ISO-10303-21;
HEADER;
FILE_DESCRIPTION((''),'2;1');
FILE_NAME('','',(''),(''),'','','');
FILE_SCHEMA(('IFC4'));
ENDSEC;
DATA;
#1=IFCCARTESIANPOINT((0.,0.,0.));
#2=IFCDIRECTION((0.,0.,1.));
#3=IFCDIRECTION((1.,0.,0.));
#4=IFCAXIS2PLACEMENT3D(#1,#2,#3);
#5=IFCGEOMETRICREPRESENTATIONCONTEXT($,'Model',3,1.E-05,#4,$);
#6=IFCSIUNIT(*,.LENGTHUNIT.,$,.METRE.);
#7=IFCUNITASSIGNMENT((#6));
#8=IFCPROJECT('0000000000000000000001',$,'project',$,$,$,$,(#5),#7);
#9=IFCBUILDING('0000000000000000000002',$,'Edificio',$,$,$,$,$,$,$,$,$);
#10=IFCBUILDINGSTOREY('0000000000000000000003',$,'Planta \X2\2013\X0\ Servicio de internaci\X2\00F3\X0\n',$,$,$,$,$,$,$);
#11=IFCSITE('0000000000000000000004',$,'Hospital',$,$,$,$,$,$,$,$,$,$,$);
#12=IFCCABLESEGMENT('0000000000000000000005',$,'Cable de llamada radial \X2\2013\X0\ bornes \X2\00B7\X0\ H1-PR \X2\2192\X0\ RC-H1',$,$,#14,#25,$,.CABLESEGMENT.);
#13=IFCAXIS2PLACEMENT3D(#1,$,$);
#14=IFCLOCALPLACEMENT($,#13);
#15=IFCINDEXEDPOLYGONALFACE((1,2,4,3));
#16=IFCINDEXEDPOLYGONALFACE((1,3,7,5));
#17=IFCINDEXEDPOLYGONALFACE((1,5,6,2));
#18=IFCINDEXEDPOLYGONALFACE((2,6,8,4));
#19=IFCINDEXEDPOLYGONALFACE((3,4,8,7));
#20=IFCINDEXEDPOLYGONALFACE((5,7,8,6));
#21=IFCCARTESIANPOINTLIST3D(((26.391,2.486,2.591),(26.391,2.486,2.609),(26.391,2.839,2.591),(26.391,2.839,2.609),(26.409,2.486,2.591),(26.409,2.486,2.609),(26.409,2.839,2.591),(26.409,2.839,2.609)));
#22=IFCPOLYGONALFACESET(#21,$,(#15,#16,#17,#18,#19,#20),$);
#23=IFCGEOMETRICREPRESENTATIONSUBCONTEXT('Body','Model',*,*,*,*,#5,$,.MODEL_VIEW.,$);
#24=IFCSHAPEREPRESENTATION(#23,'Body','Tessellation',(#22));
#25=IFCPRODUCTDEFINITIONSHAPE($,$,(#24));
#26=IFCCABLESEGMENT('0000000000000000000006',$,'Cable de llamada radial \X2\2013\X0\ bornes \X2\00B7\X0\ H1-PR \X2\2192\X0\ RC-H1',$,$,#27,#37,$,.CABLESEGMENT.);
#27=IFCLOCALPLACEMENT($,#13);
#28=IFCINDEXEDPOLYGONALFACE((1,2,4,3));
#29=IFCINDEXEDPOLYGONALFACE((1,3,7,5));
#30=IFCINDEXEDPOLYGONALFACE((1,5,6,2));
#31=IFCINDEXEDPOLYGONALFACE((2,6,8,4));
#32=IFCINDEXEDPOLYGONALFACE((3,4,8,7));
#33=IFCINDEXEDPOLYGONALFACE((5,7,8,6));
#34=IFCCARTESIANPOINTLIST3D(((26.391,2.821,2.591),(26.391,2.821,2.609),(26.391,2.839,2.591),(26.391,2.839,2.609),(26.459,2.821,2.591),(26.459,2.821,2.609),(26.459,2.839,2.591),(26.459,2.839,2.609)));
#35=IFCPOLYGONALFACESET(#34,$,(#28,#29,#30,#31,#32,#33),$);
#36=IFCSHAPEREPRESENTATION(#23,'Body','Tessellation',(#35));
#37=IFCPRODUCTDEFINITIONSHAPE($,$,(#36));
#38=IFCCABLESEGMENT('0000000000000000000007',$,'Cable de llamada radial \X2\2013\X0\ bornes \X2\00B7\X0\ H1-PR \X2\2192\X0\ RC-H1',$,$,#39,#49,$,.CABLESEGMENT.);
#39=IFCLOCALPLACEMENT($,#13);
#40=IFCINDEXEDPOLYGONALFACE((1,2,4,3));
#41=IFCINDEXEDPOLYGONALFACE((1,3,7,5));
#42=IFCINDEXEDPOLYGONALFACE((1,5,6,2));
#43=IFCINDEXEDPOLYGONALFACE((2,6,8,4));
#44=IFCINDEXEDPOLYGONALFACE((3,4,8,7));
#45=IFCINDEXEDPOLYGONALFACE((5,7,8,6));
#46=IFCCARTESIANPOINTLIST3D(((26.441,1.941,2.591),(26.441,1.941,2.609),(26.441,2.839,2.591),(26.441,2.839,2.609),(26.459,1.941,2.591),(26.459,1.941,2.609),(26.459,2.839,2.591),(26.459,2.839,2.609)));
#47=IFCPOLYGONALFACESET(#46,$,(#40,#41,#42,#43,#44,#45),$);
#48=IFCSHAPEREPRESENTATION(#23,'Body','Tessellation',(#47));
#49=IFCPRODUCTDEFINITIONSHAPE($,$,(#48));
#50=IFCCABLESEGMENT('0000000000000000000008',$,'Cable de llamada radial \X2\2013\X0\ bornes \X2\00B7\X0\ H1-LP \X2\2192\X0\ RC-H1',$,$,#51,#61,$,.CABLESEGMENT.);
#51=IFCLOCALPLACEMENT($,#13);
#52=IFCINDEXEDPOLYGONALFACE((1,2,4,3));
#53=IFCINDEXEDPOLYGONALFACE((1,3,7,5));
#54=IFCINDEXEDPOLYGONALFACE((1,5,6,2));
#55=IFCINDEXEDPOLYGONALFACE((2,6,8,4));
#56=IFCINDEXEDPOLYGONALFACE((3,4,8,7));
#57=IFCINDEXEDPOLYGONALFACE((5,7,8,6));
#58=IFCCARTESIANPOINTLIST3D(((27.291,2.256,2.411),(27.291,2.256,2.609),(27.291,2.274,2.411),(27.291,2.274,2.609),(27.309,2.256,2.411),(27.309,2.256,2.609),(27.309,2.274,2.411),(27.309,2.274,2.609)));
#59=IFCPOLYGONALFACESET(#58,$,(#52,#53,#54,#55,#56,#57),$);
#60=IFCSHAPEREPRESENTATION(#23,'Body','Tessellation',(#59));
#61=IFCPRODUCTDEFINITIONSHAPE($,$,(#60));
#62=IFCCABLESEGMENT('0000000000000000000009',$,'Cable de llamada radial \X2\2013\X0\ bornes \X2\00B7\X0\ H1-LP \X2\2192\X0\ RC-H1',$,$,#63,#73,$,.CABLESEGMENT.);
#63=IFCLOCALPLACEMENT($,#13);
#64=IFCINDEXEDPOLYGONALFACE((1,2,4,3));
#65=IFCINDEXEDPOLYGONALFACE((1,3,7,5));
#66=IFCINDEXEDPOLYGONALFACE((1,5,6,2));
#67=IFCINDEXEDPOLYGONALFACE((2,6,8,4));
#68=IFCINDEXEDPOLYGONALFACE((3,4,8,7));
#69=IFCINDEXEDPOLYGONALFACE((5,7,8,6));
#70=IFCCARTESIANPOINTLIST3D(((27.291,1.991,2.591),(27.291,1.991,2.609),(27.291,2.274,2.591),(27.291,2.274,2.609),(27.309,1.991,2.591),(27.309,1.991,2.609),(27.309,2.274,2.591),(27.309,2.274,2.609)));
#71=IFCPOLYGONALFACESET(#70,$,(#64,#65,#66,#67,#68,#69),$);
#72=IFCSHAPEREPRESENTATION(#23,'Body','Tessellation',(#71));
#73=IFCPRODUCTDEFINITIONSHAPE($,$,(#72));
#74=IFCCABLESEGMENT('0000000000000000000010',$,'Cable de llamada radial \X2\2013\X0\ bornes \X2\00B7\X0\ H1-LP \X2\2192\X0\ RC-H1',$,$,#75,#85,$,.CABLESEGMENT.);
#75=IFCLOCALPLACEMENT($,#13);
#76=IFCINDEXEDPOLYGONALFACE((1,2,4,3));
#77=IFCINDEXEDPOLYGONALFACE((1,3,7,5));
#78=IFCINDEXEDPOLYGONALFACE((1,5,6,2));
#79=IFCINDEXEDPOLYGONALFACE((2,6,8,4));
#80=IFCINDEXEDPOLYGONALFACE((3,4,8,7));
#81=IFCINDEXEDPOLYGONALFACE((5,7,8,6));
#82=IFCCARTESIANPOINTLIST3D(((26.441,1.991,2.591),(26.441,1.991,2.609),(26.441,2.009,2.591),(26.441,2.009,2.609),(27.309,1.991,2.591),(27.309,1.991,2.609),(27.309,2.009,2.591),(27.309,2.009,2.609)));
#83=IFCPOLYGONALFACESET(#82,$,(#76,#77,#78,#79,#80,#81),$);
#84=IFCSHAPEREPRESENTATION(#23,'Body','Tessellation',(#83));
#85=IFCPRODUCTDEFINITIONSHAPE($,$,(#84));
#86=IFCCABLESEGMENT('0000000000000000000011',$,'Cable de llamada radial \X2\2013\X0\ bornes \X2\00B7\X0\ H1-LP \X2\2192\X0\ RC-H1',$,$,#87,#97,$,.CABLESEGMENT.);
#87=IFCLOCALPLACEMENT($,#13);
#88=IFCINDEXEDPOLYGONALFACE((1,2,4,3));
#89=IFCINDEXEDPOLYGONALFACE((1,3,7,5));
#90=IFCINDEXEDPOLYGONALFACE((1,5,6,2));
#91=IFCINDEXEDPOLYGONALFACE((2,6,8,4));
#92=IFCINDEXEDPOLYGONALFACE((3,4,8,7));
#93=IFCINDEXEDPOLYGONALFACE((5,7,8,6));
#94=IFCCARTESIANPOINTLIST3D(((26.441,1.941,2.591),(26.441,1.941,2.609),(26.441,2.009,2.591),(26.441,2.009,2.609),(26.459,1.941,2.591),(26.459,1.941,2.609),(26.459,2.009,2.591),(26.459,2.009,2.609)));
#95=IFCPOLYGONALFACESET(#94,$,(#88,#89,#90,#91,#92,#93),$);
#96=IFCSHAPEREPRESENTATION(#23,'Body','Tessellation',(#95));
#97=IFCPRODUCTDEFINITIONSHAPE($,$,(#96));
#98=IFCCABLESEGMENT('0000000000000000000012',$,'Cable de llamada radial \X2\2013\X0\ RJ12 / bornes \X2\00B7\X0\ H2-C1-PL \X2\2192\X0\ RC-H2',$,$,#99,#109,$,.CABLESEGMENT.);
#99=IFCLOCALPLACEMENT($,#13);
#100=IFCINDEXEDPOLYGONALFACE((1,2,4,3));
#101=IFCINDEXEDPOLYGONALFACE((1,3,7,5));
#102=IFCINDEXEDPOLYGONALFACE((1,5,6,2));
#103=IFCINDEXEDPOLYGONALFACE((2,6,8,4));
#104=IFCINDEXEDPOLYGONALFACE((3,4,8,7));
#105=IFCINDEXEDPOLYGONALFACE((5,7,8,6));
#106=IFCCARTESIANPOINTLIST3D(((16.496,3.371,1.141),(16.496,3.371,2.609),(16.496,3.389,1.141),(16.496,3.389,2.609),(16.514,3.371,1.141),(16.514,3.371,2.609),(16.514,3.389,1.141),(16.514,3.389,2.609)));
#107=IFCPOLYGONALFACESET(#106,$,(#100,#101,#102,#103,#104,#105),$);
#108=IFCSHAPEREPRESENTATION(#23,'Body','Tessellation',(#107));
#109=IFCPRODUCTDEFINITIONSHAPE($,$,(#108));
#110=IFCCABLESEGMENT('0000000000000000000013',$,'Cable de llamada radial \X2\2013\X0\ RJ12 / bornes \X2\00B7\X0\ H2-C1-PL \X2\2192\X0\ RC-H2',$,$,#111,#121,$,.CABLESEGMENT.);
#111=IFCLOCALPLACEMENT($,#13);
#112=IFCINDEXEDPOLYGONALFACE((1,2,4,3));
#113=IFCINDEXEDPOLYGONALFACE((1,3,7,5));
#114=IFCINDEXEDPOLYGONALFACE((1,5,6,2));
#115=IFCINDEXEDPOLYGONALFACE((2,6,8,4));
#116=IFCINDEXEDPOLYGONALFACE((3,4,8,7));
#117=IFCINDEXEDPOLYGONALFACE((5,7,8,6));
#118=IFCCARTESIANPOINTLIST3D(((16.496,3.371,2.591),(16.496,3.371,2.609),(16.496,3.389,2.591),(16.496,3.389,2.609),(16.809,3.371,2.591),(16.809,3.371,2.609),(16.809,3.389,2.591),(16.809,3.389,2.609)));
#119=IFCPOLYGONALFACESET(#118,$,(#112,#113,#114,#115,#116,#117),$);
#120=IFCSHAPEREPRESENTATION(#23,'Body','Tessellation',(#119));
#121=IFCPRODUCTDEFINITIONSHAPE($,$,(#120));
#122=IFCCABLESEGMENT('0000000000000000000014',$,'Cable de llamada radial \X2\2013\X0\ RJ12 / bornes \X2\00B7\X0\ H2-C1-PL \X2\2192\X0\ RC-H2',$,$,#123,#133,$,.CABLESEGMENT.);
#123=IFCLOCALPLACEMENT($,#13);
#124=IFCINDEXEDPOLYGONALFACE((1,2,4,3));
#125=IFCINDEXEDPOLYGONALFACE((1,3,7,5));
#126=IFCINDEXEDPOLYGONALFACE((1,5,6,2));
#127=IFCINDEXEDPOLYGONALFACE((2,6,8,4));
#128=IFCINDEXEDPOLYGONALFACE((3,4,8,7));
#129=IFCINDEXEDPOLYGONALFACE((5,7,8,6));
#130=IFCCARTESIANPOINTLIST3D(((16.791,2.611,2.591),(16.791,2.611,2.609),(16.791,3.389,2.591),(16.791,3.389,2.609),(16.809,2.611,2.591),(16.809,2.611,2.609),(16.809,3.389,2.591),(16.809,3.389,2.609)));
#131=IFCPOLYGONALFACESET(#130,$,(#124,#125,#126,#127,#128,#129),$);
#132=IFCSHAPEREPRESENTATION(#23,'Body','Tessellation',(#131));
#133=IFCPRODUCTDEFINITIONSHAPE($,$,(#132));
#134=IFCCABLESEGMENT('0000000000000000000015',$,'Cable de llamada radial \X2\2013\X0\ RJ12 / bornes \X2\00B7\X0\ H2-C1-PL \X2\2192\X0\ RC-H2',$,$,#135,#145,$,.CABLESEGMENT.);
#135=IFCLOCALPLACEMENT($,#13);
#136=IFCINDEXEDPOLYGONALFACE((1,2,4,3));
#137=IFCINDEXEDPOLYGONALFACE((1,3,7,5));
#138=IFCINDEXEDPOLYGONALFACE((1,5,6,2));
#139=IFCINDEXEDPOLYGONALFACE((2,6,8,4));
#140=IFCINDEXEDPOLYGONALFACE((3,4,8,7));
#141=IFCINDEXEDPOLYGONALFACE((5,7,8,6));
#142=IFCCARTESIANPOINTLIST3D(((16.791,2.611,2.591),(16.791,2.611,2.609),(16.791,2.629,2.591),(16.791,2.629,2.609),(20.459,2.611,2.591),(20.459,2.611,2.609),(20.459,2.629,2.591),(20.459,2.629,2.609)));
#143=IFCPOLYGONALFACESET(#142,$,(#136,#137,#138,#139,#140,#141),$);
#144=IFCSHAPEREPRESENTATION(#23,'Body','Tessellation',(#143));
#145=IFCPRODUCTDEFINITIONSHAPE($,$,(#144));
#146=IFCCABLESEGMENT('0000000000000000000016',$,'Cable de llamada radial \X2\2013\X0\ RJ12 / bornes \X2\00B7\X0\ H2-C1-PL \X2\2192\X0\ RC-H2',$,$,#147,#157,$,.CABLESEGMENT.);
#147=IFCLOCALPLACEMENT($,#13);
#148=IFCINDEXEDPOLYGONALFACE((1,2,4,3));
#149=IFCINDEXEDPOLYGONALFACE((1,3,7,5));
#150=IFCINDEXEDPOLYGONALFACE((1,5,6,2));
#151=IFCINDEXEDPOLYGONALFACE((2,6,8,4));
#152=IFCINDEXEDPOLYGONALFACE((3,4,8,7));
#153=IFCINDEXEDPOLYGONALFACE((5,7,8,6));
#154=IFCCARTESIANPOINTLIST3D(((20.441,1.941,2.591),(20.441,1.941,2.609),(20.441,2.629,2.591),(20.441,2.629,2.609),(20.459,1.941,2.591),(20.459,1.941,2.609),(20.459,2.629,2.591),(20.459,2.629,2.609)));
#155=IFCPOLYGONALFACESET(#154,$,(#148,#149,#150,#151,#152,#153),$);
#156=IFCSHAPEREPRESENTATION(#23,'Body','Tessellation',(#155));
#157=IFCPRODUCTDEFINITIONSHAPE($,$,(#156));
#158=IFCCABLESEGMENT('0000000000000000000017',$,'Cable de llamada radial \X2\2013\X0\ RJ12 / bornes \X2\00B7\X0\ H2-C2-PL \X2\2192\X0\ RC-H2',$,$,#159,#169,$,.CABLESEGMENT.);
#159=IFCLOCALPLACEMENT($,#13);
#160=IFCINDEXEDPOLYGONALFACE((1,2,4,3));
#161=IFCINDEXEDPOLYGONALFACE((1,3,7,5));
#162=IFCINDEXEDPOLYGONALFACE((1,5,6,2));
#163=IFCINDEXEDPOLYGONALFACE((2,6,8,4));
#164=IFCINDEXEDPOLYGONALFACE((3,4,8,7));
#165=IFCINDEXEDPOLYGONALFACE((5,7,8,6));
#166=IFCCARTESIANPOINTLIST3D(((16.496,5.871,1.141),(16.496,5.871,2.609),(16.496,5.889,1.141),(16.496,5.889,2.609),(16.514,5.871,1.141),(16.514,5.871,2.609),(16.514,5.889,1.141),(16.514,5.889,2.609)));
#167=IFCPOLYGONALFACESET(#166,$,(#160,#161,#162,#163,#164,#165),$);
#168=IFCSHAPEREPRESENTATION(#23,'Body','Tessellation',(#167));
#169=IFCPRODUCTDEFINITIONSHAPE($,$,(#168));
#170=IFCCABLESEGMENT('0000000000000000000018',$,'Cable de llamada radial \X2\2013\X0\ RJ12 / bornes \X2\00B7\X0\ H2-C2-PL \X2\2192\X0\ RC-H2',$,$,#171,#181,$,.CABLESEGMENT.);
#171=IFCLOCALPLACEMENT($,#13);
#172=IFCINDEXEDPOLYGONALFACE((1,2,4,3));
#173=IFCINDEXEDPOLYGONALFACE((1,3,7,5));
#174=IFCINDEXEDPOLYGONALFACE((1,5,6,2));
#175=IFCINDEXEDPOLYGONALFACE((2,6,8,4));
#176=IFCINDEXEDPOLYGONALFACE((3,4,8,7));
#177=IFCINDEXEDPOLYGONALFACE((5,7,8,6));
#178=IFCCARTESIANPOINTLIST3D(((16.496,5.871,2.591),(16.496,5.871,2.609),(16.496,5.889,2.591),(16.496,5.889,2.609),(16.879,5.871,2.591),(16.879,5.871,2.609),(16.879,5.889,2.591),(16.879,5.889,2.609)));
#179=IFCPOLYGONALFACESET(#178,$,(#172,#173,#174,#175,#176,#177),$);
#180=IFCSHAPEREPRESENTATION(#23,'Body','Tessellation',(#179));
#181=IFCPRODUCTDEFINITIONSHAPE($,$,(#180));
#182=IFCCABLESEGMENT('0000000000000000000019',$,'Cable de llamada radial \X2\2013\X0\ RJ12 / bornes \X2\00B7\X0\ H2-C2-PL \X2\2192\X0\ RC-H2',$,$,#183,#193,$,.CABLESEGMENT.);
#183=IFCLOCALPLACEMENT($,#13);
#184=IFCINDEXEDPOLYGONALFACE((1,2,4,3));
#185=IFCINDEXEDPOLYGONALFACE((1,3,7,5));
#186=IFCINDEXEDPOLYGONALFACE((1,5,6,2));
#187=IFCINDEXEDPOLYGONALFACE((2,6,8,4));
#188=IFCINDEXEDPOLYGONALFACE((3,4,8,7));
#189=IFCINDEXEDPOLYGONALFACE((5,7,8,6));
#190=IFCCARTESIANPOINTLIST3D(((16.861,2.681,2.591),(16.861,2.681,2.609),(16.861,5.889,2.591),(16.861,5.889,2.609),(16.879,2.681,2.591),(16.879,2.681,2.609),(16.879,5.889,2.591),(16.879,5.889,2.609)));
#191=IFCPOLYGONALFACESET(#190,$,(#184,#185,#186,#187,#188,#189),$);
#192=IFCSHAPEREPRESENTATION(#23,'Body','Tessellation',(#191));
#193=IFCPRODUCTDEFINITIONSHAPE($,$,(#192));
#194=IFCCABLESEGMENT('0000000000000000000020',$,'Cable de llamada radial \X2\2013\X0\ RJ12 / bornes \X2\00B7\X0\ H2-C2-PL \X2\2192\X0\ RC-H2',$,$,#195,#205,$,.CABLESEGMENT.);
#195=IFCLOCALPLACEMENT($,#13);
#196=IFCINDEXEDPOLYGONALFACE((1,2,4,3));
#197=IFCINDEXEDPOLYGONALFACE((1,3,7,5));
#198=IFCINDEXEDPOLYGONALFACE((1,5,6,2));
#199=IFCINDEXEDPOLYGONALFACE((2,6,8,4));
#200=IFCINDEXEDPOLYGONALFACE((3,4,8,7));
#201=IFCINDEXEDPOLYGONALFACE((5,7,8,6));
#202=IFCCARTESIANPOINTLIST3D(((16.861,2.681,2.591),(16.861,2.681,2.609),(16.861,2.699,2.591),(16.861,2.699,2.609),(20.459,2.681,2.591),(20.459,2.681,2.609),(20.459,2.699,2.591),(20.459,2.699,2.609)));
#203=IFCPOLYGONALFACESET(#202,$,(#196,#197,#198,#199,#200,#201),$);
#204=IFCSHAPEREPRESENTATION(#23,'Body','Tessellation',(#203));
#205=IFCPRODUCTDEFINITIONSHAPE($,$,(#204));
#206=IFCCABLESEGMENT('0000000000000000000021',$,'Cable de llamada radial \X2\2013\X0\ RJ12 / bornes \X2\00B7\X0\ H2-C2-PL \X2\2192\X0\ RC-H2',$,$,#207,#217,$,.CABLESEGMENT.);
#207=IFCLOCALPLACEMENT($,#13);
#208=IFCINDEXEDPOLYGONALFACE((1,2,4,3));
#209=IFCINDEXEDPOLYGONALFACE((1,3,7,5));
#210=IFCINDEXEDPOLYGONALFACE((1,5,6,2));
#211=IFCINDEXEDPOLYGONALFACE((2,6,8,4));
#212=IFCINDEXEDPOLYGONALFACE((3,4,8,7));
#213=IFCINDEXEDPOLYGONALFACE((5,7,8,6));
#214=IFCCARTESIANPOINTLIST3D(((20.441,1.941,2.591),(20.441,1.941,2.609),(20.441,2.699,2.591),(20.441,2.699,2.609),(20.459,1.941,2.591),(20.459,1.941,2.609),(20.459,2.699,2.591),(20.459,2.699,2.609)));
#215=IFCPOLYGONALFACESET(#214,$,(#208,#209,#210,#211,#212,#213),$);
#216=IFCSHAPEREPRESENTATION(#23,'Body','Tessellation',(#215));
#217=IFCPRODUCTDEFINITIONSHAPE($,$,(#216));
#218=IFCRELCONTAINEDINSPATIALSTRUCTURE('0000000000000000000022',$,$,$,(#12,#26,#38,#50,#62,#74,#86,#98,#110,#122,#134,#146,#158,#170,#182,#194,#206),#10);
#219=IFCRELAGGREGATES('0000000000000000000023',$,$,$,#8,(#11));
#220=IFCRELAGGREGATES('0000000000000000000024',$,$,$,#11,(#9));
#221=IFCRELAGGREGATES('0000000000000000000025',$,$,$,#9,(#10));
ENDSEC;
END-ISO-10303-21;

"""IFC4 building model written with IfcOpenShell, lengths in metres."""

from ifc_helpers import new_model, si_unit, frame, origin_with_axes, context, subcontext, project, spatial, line, indexed_curve, outline, extrude, element, save


model = new_model("IFC4")

# Units and contexts
model_context = context("Model", 3, precision=1e-05, world=origin_with_axes())
body_context = subcontext(model_context, "Body", "Model", "MODEL_VIEW")
ifc_project = project(units=[si_unit("LENGTHUNIT", "METRE")], contexts=[model_context])

# Site, building, storey
site = spatial("IfcSite", under=ifc_project, Name="Hospital")
building = spatial("IfcBuilding", under=site, Name="Edificio")
storey = spatial("IfcBuildingStorey", under=building, Name="Planta – Servicio de internación")

# Cable segments
element("IfcCableSegment", 1, inside=storey, Name="Cable de llamada radial – bornes · H1-PR → RC-H1", PredefinedType="CABLESEGMENT", context=body_context, shape_type="SweptSolid", body=[
    extrude(outline(indexed_curve([(0.0, 0.0), (0.018, 0.0), (0.018, 0.353), (0.0, 0.353)], segments=[line(1, 2, 3, 4, 1)])), frame((26.391, 2.486, 2.591), z_axis=(0.0, 0.0, 1.0), x_axis=(1.0, 0.0, 0.0)), (0.0, 0.0, 1.0), 0.018),
])
element("IfcCableSegment", 2, inside=storey, Name="Cable de llamada radial – bornes · H1-PR → RC-H1", PredefinedType="CABLESEGMENT", context=body_context, shape_type="SweptSolid", body=[
    extrude(outline(indexed_curve([(0.0, 0.0), (0.068, 0.0), (0.068, 0.018), (0.0, 0.018)], segments=[line(1, 2, 3, 4, 1)])), frame((26.391, 2.821, 2.591), z_axis=(0.0, 0.0, 1.0), x_axis=(1.0, 0.0, 0.0)), (0.0, 0.0, 1.0), 0.018),
])
element("IfcCableSegment", 3, inside=storey, Name="Cable de llamada radial – bornes · H1-PR → RC-H1", PredefinedType="CABLESEGMENT", context=body_context, shape_type="SweptSolid", body=[
    extrude(outline(indexed_curve([(0.0, 0.0), (0.018, 0.0), (0.018, 0.898), (0.0, 0.898)], segments=[line(1, 2, 3, 4, 1)])), frame((26.441, 1.941, 2.591), z_axis=(0.0, 0.0, 1.0), x_axis=(1.0, 0.0, 0.0)), (0.0, 0.0, 1.0), 0.018),
])
element("IfcCableSegment", 4, inside=storey, Name="Cable de llamada radial – bornes · H1-LP → RC-H1", PredefinedType="CABLESEGMENT", context=body_context, shape_type="SweptSolid", body=[
    extrude(outline(indexed_curve([(0.0, 0.0), (0.018, 0.0), (0.018, 0.018), (0.0, 0.018)], segments=[line(1, 2, 3, 4, 1)])), frame((27.291, 2.256, 2.411), z_axis=(0.0, 0.0, 1.0), x_axis=(1.0, 0.0, 0.0)), (0.0, 0.0, 1.0), 0.198),
])
element("IfcCableSegment", 5, inside=storey, Name="Cable de llamada radial – bornes · H1-LP → RC-H1", PredefinedType="CABLESEGMENT", context=body_context, shape_type="SweptSolid", body=[
    extrude(outline(indexed_curve([(0.0, 0.0), (0.018, 0.0), (0.018, 0.283), (0.0, 0.283)], segments=[line(1, 2, 3, 4, 1)])), frame((27.291, 1.991, 2.591), z_axis=(0.0, 0.0, 1.0), x_axis=(1.0, 0.0, 0.0)), (0.0, 0.0, 1.0), 0.018),
])
element("IfcCableSegment", 6, inside=storey, Name="Cable de llamada radial – bornes · H1-LP → RC-H1", PredefinedType="CABLESEGMENT", context=body_context, shape_type="SweptSolid", body=[
    extrude(outline(indexed_curve([(0.0, 0.0), (0.868, 0.0), (0.868, 0.018), (0.0, 0.018)], segments=[line(1, 2, 3, 4, 1)])), frame((26.441, 1.991, 2.591), z_axis=(0.0, 0.0, 1.0), x_axis=(1.0, 0.0, 0.0)), (0.0, 0.0, 1.0), 0.018),
])
element("IfcCableSegment", 7, inside=storey, Name="Cable de llamada radial – bornes · H1-LP → RC-H1", PredefinedType="CABLESEGMENT", context=body_context, shape_type="SweptSolid", body=[
    extrude(outline(indexed_curve([(0.0, 0.0), (0.018, 0.0), (0.018, 0.068), (0.0, 0.068)], segments=[line(1, 2, 3, 4, 1)])), frame((26.441, 1.941, 2.591), z_axis=(0.0, 0.0, 1.0), x_axis=(1.0, 0.0, 0.0)), (0.0, 0.0, 1.0), 0.018),
])
element("IfcCableSegment", 8, inside=storey, Name="Cable de llamada radial – RJ12 / bornes · H2-C1-PL → RC-H2", PredefinedType="CABLESEGMENT", context=body_context, shape_type="SweptSolid", body=[
    extrude(outline(indexed_curve([(0.0, 0.0), (0.018, 0.0), (0.018, 0.018), (0.0, 0.018)], segments=[line(1, 2, 3, 4, 1)])), frame((16.496, 3.371, 1.141), z_axis=(0.0, 0.0, 1.0), x_axis=(1.0, 0.0, 0.0)), (0.0, 0.0, 1.0), 1.468),
])
element("IfcCableSegment", 9, inside=storey, Name="Cable de llamada radial – RJ12 / bornes · H2-C1-PL → RC-H2", PredefinedType="CABLESEGMENT", context=body_context, shape_type="SweptSolid", body=[
    extrude(outline(indexed_curve([(0.0, 0.0), (0.313, 0.0), (0.313, 0.018), (0.0, 0.018)], segments=[line(1, 2, 3, 4, 1)])), frame((16.496, 3.371, 2.591), z_axis=(0.0, 0.0, 1.0), x_axis=(1.0, 0.0, 0.0)), (0.0, 0.0, 1.0), 0.018),
])
element("IfcCableSegment", 10, inside=storey, Name="Cable de llamada radial – RJ12 / bornes · H2-C1-PL → RC-H2", PredefinedType="CABLESEGMENT", context=body_context, shape_type="SweptSolid", body=[
    extrude(outline(indexed_curve([(0.0, 0.0), (0.018, 0.0), (0.018, 0.778), (0.0, 0.778)], segments=[line(1, 2, 3, 4, 1)])), frame((16.791, 2.611, 2.591), z_axis=(0.0, 0.0, 1.0), x_axis=(1.0, 0.0, 0.0)), (0.0, 0.0, 1.0), 0.018),
])
element("IfcCableSegment", 11, inside=storey, Name="Cable de llamada radial – RJ12 / bornes · H2-C1-PL → RC-H2", PredefinedType="CABLESEGMENT", context=body_context, shape_type="SweptSolid", body=[
    extrude(outline(indexed_curve([(0.0, 0.0), (3.668, 0.0), (3.668, 0.018), (0.0, 0.018)], segments=[line(1, 2, 3, 4, 1)])), frame((16.791, 2.611, 2.591), z_axis=(0.0, 0.0, 1.0), x_axis=(1.0, 0.0, 0.0)), (0.0, 0.0, 1.0), 0.018),
])
element("IfcCableSegment", 12, inside=storey, Name="Cable de llamada radial – RJ12 / bornes · H2-C1-PL → RC-H2", PredefinedType="CABLESEGMENT", context=body_context, shape_type="SweptSolid", body=[
    extrude(outline(indexed_curve([(0.0, 0.0), (0.018, 0.0), (0.018, 0.688), (0.0, 0.688)], segments=[line(1, 2, 3, 4, 1)])), frame((20.441, 1.941, 2.591), z_axis=(0.0, 0.0, 1.0), x_axis=(1.0, 0.0, 0.0)), (0.0, 0.0, 1.0), 0.018),
])
element("IfcCableSegment", 13, inside=storey, Name="Cable de llamada radial – RJ12 / bornes · H2-C2-PL → RC-H2", PredefinedType="CABLESEGMENT", context=body_context, shape_type="SweptSolid", body=[
    extrude(outline(indexed_curve([(0.0, 0.0), (0.018, 0.0), (0.018, 0.018), (0.0, 0.018)], segments=[line(1, 2, 3, 4, 1)])), frame((16.496, 5.871, 1.141), z_axis=(0.0, 0.0, 1.0), x_axis=(1.0, 0.0, 0.0)), (0.0, 0.0, 1.0), 1.468),
])
element("IfcCableSegment", 14, inside=storey, Name="Cable de llamada radial – RJ12 / bornes · H2-C2-PL → RC-H2", PredefinedType="CABLESEGMENT", context=body_context, shape_type="SweptSolid", body=[
    extrude(outline(indexed_curve([(0.0, 0.0), (0.383, 0.0), (0.383, 0.018), (0.0, 0.018)], segments=[line(1, 2, 3, 4, 1)])), frame((16.496, 5.871, 2.591), z_axis=(0.0, 0.0, 1.0), x_axis=(1.0, 0.0, 0.0)), (0.0, 0.0, 1.0), 0.018),
])
element("IfcCableSegment", 15, inside=storey, Name="Cable de llamada radial – RJ12 / bornes · H2-C2-PL → RC-H2", PredefinedType="CABLESEGMENT", context=body_context, shape_type="SweptSolid", body=[
    extrude(outline(indexed_curve([(0.0, 0.0), (0.018, 0.0), (0.018, 3.208), (0.0, 3.208)], segments=[line(1, 2, 3, 4, 1)])), frame((16.861, 2.681, 2.591), z_axis=(0.0, 0.0, 1.0), x_axis=(1.0, 0.0, 0.0)), (0.0, 0.0, 1.0), 0.018),
])
element("IfcCableSegment", 16, inside=storey, Name="Cable de llamada radial – RJ12 / bornes · H2-C2-PL → RC-H2", PredefinedType="CABLESEGMENT", context=body_context, shape_type="SweptSolid", body=[
    extrude(outline(indexed_curve([(0.0, 0.0), (3.598, 0.0), (3.598, 0.018), (0.0, 0.018)], segments=[line(1, 2, 3, 4, 1)])), frame((16.861, 2.681, 2.591), z_axis=(0.0, 0.0, 1.0), x_axis=(1.0, 0.0, 0.0)), (0.0, 0.0, 1.0), 0.018),
])
element("IfcCableSegment", 17, inside=storey, Name="Cable de llamada radial – RJ12 / bornes · H2-C2-PL → RC-H2", PredefinedType="CABLESEGMENT", context=body_context, shape_type="SweptSolid", body=[
    extrude(outline(indexed_curve([(0.0, 0.0), (0.018, 0.0), (0.018, 0.758), (0.0, 0.758)], segments=[line(1, 2, 3, 4, 1)])), frame((20.441, 1.941, 2.591), z_axis=(0.0, 0.0, 1.0), x_axis=(1.0, 0.0, 0.0)), (0.0, 0.0, 1.0), 0.018),
])

save(model, "model.ifc")
